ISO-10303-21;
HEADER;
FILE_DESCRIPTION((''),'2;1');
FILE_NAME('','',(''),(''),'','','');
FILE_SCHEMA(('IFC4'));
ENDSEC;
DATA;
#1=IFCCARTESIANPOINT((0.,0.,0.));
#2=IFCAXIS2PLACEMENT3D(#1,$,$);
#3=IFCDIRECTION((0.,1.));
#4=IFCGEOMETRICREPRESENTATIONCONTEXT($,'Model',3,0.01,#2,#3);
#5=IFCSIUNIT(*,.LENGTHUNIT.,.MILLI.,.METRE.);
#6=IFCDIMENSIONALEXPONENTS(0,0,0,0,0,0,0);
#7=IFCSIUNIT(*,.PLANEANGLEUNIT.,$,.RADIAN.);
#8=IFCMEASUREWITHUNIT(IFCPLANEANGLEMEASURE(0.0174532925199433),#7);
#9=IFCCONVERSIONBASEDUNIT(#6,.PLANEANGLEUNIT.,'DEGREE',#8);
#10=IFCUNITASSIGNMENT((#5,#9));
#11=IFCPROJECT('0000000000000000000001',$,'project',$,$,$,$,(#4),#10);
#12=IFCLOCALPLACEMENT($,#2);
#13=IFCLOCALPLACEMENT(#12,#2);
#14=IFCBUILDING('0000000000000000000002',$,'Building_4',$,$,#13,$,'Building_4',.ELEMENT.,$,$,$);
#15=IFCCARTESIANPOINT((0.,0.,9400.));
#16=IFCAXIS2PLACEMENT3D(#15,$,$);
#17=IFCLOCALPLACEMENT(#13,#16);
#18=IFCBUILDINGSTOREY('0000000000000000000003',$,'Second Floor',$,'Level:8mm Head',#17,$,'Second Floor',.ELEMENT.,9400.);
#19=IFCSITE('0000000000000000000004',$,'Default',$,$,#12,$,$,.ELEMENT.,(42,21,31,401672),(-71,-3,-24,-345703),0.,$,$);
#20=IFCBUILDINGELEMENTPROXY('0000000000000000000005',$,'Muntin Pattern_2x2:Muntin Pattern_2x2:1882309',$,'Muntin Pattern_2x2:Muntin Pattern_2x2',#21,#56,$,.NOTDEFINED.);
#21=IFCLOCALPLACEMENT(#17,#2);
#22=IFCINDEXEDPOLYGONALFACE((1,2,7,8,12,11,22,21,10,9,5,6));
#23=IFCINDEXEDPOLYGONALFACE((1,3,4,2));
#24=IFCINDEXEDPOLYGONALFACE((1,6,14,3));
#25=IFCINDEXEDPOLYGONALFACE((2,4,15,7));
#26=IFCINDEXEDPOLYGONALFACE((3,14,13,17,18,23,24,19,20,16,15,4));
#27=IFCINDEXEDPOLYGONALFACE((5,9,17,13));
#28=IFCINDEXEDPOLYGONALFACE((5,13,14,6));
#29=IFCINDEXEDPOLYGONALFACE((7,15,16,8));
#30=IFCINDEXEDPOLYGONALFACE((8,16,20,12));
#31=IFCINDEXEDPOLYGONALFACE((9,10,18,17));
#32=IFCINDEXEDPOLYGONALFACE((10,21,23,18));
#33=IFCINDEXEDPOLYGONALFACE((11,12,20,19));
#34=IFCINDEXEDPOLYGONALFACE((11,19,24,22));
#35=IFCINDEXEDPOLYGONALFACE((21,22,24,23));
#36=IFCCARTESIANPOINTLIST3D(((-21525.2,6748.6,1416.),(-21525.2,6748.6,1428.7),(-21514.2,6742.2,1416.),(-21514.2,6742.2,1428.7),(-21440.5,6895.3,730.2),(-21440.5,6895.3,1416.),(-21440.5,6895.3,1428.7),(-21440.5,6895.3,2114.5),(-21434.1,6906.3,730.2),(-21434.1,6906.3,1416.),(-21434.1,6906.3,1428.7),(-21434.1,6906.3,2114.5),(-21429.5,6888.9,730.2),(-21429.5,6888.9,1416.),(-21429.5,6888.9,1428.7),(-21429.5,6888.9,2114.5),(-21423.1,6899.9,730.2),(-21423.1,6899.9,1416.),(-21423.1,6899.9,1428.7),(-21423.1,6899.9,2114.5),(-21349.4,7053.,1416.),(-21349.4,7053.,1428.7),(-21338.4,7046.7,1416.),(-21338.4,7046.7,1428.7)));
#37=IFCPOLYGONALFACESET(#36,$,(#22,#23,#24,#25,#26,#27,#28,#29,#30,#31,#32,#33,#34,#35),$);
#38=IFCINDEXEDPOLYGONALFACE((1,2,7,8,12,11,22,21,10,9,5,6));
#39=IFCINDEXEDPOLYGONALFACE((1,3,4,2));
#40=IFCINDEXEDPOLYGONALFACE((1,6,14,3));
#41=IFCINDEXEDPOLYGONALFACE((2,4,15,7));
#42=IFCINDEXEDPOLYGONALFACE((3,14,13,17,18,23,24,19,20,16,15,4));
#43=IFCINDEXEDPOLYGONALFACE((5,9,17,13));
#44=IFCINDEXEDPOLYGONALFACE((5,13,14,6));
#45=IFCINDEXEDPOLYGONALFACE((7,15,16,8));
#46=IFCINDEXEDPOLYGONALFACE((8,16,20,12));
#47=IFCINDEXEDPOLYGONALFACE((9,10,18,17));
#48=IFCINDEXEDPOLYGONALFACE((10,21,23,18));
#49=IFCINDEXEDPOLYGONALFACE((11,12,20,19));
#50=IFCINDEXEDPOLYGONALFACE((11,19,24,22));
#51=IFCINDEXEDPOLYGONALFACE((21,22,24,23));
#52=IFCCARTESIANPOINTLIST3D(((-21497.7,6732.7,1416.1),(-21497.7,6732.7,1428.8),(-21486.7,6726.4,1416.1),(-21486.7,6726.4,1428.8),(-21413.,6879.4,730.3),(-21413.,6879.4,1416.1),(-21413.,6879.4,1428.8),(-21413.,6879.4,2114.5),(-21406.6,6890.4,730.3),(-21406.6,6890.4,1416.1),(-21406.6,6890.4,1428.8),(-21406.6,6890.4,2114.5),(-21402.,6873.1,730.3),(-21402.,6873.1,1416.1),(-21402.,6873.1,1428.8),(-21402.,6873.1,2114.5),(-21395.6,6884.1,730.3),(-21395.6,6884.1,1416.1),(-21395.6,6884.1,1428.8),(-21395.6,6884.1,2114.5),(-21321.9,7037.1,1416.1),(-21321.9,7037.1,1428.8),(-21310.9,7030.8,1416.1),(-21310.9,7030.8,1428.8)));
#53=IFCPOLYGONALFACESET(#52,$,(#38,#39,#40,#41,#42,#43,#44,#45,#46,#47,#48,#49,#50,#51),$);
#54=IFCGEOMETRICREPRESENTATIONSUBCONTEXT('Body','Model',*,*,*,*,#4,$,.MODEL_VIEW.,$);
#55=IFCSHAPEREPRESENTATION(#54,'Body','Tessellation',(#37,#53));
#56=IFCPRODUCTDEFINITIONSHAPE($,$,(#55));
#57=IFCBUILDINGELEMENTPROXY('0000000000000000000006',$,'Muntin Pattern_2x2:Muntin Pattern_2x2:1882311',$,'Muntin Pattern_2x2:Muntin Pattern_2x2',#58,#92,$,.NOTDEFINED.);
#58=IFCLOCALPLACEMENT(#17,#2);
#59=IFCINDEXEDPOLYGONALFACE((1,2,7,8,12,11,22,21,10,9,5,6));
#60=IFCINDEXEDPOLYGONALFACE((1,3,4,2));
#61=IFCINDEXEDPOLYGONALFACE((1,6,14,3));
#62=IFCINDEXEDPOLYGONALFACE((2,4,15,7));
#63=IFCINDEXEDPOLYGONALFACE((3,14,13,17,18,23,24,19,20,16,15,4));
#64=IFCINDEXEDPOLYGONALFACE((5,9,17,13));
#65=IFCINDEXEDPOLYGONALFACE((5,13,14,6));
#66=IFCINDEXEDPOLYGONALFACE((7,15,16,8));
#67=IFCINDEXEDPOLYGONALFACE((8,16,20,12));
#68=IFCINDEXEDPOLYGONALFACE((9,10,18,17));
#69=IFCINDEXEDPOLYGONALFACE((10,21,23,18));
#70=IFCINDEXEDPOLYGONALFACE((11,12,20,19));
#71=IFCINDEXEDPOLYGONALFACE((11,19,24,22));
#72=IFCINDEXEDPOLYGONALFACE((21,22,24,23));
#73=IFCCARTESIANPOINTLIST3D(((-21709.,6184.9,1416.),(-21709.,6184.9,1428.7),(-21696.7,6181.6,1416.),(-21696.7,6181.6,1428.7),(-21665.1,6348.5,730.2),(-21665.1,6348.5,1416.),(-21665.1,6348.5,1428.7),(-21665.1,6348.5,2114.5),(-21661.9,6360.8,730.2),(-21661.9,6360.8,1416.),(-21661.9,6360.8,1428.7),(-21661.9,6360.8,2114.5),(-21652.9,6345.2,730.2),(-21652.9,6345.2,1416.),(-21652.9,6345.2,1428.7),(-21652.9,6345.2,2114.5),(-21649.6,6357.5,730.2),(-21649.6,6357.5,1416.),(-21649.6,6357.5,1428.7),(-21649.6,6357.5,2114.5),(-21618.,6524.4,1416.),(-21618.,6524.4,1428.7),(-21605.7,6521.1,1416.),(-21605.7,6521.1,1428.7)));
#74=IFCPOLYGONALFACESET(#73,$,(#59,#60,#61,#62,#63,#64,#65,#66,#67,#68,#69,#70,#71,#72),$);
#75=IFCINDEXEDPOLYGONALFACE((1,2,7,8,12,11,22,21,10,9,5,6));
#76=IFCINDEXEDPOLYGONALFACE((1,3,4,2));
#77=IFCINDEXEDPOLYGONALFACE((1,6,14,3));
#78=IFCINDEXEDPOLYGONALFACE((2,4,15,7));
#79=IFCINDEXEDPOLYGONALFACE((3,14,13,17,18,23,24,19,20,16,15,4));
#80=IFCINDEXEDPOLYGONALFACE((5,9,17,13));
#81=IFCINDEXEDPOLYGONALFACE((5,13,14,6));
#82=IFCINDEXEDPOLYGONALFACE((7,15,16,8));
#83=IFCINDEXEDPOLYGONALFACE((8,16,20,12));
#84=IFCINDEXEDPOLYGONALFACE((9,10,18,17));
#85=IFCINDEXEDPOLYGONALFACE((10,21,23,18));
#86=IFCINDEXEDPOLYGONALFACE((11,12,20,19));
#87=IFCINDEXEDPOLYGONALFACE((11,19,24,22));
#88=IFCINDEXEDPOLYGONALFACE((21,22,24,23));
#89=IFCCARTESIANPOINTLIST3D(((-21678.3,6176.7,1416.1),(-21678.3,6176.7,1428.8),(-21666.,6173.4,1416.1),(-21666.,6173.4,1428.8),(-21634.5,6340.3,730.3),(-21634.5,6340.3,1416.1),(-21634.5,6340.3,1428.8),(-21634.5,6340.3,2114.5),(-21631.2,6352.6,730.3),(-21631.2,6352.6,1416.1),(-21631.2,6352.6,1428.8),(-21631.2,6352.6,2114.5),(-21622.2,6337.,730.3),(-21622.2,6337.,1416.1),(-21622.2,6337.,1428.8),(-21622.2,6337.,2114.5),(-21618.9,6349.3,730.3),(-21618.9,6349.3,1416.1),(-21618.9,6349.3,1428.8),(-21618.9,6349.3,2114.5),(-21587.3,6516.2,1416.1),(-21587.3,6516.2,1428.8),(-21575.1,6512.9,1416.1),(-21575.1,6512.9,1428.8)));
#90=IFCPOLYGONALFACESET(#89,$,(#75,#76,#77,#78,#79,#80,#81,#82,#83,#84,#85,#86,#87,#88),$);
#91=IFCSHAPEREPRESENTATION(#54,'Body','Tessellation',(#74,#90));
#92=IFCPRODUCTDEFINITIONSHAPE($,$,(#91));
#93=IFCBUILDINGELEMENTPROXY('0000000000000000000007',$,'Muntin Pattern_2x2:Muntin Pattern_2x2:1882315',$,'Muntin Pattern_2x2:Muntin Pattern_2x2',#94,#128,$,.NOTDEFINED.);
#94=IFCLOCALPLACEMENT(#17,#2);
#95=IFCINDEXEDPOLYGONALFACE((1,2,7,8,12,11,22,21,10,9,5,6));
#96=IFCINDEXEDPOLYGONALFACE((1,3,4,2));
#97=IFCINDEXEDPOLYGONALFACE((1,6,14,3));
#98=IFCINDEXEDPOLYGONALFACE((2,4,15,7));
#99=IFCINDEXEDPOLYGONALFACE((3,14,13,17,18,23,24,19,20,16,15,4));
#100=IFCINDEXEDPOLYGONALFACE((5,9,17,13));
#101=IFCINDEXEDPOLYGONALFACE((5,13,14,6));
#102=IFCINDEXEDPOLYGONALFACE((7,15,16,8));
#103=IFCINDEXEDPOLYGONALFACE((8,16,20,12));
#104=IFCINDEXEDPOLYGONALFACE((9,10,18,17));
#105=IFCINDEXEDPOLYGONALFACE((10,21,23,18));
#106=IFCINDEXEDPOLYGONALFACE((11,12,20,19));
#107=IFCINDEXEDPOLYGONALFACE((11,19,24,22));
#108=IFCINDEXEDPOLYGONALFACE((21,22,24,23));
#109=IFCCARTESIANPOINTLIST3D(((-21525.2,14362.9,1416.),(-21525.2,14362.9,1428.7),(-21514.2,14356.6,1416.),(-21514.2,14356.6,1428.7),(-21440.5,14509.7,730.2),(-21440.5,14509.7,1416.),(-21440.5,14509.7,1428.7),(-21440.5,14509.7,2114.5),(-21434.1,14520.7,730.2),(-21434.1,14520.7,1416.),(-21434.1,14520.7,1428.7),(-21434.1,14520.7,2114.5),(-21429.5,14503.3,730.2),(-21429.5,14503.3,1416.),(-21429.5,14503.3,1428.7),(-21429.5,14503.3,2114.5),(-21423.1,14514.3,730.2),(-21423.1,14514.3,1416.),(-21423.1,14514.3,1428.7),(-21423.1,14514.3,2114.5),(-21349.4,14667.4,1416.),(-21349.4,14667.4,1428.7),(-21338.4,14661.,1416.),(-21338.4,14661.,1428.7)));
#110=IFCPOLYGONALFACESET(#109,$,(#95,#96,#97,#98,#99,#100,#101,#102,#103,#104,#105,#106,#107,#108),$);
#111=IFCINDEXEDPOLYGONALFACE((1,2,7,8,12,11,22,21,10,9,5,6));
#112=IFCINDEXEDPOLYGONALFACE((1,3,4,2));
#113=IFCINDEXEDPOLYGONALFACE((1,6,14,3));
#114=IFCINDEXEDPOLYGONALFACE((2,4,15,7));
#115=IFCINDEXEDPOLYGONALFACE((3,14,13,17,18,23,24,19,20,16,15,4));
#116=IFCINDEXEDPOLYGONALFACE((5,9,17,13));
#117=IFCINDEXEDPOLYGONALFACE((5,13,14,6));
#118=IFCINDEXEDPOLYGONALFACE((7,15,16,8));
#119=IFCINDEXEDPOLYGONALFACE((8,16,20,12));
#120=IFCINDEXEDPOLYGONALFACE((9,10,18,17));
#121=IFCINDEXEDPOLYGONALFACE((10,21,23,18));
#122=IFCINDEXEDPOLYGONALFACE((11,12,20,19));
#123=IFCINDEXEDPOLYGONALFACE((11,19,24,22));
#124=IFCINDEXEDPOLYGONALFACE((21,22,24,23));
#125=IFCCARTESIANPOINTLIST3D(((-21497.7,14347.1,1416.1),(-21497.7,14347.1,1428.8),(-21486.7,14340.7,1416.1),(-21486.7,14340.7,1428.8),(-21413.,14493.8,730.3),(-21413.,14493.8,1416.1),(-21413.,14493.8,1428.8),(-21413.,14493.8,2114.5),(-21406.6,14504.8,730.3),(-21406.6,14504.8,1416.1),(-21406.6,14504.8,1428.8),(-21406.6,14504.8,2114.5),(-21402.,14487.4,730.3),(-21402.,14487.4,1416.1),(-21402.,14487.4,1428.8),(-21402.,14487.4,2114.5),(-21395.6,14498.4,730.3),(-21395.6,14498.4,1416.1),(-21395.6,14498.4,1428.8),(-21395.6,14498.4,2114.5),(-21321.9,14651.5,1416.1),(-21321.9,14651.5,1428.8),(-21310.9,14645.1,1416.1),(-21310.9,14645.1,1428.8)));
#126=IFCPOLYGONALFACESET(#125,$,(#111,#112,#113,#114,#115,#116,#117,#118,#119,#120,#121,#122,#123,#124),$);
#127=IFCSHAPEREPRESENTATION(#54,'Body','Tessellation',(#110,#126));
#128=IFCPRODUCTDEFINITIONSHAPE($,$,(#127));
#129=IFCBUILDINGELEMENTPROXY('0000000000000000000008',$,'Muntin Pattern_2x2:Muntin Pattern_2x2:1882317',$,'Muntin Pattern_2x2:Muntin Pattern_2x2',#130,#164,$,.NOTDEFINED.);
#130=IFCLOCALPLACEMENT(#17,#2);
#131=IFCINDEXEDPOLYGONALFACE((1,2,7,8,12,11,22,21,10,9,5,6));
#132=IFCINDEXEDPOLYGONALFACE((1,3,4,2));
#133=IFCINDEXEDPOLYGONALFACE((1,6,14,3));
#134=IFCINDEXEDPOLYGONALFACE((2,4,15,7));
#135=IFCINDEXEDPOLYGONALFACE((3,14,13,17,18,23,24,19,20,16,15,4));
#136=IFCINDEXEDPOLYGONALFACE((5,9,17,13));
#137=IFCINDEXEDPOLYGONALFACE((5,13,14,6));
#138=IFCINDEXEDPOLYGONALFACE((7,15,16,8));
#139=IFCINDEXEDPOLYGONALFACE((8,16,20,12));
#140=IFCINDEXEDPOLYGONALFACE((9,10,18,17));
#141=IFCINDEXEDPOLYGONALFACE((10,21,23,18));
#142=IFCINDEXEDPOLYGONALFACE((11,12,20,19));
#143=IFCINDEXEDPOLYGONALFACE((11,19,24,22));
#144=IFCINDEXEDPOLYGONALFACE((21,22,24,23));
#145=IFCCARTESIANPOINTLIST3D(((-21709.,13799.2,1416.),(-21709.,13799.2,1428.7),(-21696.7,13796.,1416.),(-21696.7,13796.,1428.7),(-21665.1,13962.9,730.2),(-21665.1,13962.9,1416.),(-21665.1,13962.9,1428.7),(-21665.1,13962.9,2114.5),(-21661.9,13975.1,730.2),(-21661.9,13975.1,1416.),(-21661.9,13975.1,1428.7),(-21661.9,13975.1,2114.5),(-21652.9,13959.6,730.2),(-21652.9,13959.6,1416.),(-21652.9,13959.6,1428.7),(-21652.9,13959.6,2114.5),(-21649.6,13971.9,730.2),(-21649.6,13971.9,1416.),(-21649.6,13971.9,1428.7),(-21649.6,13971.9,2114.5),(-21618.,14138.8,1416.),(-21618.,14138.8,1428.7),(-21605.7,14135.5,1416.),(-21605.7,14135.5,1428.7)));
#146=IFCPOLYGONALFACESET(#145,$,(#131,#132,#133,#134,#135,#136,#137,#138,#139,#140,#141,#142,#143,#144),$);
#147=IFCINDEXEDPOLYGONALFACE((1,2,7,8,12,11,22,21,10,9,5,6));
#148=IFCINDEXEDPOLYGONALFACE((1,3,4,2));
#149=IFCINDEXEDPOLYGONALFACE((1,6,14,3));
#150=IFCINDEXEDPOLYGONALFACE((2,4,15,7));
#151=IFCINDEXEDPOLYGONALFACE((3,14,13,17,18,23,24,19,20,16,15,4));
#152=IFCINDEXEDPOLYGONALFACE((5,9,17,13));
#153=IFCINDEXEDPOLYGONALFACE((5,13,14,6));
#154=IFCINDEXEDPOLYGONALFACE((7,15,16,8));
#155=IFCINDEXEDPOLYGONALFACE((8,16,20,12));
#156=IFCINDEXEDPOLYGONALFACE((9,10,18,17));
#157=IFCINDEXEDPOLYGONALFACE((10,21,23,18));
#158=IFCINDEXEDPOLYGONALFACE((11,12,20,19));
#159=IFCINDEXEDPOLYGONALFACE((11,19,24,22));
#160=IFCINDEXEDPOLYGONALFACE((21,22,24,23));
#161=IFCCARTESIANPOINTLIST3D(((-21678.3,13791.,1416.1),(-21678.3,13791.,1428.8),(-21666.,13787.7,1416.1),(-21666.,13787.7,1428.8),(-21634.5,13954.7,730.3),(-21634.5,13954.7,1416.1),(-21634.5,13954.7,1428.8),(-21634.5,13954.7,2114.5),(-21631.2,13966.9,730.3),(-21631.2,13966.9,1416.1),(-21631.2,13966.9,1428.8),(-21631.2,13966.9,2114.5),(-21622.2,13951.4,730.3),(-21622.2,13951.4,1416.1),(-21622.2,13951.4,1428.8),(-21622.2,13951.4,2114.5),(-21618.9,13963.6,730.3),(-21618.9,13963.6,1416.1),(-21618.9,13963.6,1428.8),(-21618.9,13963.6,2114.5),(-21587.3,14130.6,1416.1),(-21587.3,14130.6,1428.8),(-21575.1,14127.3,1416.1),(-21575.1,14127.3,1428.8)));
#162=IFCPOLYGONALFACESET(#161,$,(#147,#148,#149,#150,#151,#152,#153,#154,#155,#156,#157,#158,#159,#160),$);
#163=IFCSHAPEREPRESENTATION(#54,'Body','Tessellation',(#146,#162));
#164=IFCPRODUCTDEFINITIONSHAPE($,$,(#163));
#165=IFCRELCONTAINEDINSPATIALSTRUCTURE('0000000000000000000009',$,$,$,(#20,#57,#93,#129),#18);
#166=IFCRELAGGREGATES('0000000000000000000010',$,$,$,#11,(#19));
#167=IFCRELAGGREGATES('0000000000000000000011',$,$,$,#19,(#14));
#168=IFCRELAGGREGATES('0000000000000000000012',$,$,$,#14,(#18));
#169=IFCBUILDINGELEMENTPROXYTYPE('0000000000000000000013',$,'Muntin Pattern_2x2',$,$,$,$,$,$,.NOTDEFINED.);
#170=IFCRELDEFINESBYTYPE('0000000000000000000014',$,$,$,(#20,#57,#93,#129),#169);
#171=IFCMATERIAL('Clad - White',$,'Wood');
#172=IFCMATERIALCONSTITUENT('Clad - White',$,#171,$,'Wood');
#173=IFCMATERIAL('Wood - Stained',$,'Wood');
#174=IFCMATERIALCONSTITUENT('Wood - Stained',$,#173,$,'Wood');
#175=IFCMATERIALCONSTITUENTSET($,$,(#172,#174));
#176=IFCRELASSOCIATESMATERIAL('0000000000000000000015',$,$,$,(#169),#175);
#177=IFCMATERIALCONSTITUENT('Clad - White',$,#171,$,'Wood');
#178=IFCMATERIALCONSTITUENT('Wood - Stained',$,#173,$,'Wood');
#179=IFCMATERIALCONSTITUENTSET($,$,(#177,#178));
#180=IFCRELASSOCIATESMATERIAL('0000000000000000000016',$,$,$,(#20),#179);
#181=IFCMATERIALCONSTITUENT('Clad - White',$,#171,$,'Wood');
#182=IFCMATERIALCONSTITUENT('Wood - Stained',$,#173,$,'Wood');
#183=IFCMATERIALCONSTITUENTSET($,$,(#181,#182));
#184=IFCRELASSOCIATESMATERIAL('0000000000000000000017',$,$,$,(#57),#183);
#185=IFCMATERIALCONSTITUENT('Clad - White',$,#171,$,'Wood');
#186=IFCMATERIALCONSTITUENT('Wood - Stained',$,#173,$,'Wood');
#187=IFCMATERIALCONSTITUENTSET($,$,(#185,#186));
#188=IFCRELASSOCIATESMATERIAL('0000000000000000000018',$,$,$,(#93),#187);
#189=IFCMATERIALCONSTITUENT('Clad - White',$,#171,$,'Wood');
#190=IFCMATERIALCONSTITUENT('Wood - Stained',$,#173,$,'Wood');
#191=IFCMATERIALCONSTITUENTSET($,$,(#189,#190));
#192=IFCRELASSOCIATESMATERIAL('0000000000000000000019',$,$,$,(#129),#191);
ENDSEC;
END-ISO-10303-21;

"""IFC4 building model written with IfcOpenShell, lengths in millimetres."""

from ifc_helpers import new_model, entity, si_unit, converted_unit, direction, frame, origin, place, context, subcontext, project, spatial, indexed_curve, outline, extrude, source, transform, mapped, material, constituent, constituent_set, type_object, type_shapes, element, save


model = new_model("IFC4")

# Units and contexts
model_context = context("Model", 3, precision=0.01, world=origin(), true_north=direction((0.0, 1.0)))
body_context = subcontext(model_context, "Body", "Model", "MODEL_VIEW")
ifc_project = project(units=[si_unit("LENGTHUNIT", "METRE", prefix="MILLI"), converted_unit("PLANEANGLEUNIT", "DEGREE", entity("IfcPlaneAngleMeasure", 0.0174532925199433), si_unit("PLANEANGLEUNIT", "RADIAN"), dimensions=[0, 0, 0, 0, 0, 0, 0])], contexts=[model_context])

# Site, building, storey
site_placement = place(None, origin())
site = spatial("IfcSite", under=ifc_project, at=site_placement, Name="Default", CompositionType="ELEMENT", RefLatitude=(42, 21, 31, 401672), RefLongitude=(-71, -3, -24, -345703), RefElevation=0.0)
building_placement = place(site_placement, origin())
building = spatial("IfcBuilding", under=site, at=building_placement, Name="Building_4", LongName="Building_4", CompositionType="ELEMENT")
storey_placement = place(building_placement, frame((0.0, 0.0, 9400.0)))
storey = spatial("IfcBuildingStorey", under=building, at=storey_placement, Name="Second Floor", ObjectType="Level:8mm Head", LongName="Second Floor", CompositionType="ELEMENT", Elevation=9400.0)

# Building element proxies
ifc_material_1 = material(Name="Clad - White", Category="Wood")
ifc_material_2 = material(Name="Wood - Stained", Category="Wood")
ifc_constituent_1 = constituent(ifc_material_1, Name="Clad - White", Category="Wood")
ifc_constituent_2 = constituent(ifc_material_2, Name="Wood - Stained", Category="Wood")
ifc_constituent_set_1 = constituent_set(constituents=[ifc_constituent_1, ifc_constituent_2])
building_element_proxy_type_1 = type_object("IfcBuildingElementProxyType", Name="Muntin Pattern_2x2", PredefinedType="NOTDEFINED", material=ifc_constituent_set_1)
shared_shape_1 = source(origin(), body_context, "Body", "SweptSolid", [
    extrude(outline(indexed_curve([(6.4, -6.4), (692.1, -6.4), (692.1, 6.3), (6.4, 6.3), (6.4, 175.8), (-6.3, 175.8), (-6.3, 6.3), (-692.2, 6.3), (-692.2, -6.4), (-6.3, -6.4), (-6.3, -175.8), (6.4, -175.8), (6.4, -6.4)], self_intersect=False)), frame((0.0, -22.2, 692.1), z_axis=(0.0, 1.0, 0.0), x_axis=(0.0, 0.0, 1.0)), (0.0, 0.0, 1.0), 12.7),
    extrude(outline(indexed_curve([(6.4, -6.4), (692.1, -6.4), (692.1, 6.3), (6.4, 6.3), (6.4, 175.8), (-6.3, 175.8), (-6.3, 6.3), (-692.1, 6.3), (-692.1, -6.4), (-6.3, -6.4), (-6.3, -175.8), (6.4, -175.8), (6.4, -6.4)], self_intersect=False)), frame((0.0, 9.5, 692.1), z_axis=(0.0, 1.0, 0.0), x_axis=(0.0, 0.0, 1.0)), (0.0, 0.0, 1.0), 12.7),
])
type_shapes(building_element_proxy_type_1, [shared_shape_1])
ifc_constituent_3 = constituent(ifc_material_1, Name="Clad - White", Category="Wood")
ifc_constituent_4 = constituent(ifc_material_2, Name="Wood - Stained", Category="Wood")
ifc_constituent_set_2 = constituent_set(constituents=[ifc_constituent_3, ifc_constituent_4])
proxy_1_placement = place(storey_placement, frame((-21418.0, 6889.7, 730.3), z_axis=(0.0, 0.0, 1.0), x_axis=(-0.5, -0.866025, 0.0)))
element("IfcBuildingElementProxy", 1, at=proxy_1_placement, inside=storey, type_object=building_element_proxy_type_1, material=ifc_constituent_set_2, Name="Muntin Pattern_2x2:Muntin Pattern_2x2:1882309", ObjectType="Muntin Pattern_2x2:Muntin Pattern_2x2", PredefinedType="NOTDEFINED", context=body_context, shape_type="MappedRepresentation", body=[
    mapped(shared_shape_1, transform((0.0, 0.0, 0.0), scale=1.0)),
])
ifc_constituent_5 = constituent(ifc_material_1, Name="Clad - White", Category="Wood")
ifc_constituent_6 = constituent(ifc_material_2, Name="Wood - Stained", Category="Wood")
ifc_constituent_set_3 = constituent_set(constituents=[ifc_constituent_5, ifc_constituent_6])
proxy_2_placement = place(storey_placement, frame((-21642.0, 6348.9, 730.3), z_axis=(0.0, 0.0, 1.0), x_axis=(-0.258819, -0.965926, 0.0)))
element("IfcBuildingElementProxy", 2, at=proxy_2_placement, inside=storey, type_object=building_element_proxy_type_1, material=ifc_constituent_set_3, Name="Muntin Pattern_2x2:Muntin Pattern_2x2:1882311", ObjectType="Muntin Pattern_2x2:Muntin Pattern_2x2", PredefinedType="NOTDEFINED", context=body_context, shape_type="MappedRepresentation", body=[
    mapped(shared_shape_1, transform((0.0, 0.0, 0.0), scale=1.0)),
])
ifc_constituent_7 = constituent(ifc_material_1, Name="Clad - White", Category="Wood")
ifc_constituent_8 = constituent(ifc_material_2, Name="Wood - Stained", Category="Wood")
ifc_constituent_set_4 = constituent_set(constituents=[ifc_constituent_7, ifc_constituent_8])
proxy_3_placement = place(storey_placement, frame((-21418.0, 14504.0, 730.3), z_axis=(0.0, 0.0, 1.0), x_axis=(-0.5, -0.866025, 0.0)))
element("IfcBuildingElementProxy", 3, at=proxy_3_placement, inside=storey, type_object=building_element_proxy_type_1, material=ifc_constituent_set_4, Name="Muntin Pattern_2x2:Muntin Pattern_2x2:1882315", ObjectType="Muntin Pattern_2x2:Muntin Pattern_2x2", PredefinedType="NOTDEFINED", context=body_context, shape_type="MappedRepresentation", body=[
    mapped(shared_shape_1, transform((0.0, 0.0, 0.0), scale=1.0)),
])
ifc_constituent_9 = constituent(ifc_material_1, Name="Clad - White", Category="Wood")
ifc_constituent_10 = constituent(ifc_material_2, Name="Wood - Stained", Category="Wood")
ifc_constituent_set_5 = constituent_set(constituents=[ifc_constituent_9, ifc_constituent_10])
proxy_4_placement = place(storey_placement, frame((-21642.0, 13963.3, 730.3), z_axis=(0.0, 0.0, 1.0), x_axis=(-0.258819, -0.965926, 0.0)))
element("IfcBuildingElementProxy", 4, at=proxy_4_placement, inside=storey, type_object=building_element_proxy_type_1, material=ifc_constituent_set_5, Name="Muntin Pattern_2x2:Muntin Pattern_2x2:1882317", ObjectType="Muntin Pattern_2x2:Muntin Pattern_2x2", PredefinedType="NOTDEFINED", context=body_context, shape_type="MappedRepresentation", body=[
    mapped(shared_shape_1, transform((0.0, 0.0, 0.0), scale=1.0)),
])

save(model, "model.ifc")
